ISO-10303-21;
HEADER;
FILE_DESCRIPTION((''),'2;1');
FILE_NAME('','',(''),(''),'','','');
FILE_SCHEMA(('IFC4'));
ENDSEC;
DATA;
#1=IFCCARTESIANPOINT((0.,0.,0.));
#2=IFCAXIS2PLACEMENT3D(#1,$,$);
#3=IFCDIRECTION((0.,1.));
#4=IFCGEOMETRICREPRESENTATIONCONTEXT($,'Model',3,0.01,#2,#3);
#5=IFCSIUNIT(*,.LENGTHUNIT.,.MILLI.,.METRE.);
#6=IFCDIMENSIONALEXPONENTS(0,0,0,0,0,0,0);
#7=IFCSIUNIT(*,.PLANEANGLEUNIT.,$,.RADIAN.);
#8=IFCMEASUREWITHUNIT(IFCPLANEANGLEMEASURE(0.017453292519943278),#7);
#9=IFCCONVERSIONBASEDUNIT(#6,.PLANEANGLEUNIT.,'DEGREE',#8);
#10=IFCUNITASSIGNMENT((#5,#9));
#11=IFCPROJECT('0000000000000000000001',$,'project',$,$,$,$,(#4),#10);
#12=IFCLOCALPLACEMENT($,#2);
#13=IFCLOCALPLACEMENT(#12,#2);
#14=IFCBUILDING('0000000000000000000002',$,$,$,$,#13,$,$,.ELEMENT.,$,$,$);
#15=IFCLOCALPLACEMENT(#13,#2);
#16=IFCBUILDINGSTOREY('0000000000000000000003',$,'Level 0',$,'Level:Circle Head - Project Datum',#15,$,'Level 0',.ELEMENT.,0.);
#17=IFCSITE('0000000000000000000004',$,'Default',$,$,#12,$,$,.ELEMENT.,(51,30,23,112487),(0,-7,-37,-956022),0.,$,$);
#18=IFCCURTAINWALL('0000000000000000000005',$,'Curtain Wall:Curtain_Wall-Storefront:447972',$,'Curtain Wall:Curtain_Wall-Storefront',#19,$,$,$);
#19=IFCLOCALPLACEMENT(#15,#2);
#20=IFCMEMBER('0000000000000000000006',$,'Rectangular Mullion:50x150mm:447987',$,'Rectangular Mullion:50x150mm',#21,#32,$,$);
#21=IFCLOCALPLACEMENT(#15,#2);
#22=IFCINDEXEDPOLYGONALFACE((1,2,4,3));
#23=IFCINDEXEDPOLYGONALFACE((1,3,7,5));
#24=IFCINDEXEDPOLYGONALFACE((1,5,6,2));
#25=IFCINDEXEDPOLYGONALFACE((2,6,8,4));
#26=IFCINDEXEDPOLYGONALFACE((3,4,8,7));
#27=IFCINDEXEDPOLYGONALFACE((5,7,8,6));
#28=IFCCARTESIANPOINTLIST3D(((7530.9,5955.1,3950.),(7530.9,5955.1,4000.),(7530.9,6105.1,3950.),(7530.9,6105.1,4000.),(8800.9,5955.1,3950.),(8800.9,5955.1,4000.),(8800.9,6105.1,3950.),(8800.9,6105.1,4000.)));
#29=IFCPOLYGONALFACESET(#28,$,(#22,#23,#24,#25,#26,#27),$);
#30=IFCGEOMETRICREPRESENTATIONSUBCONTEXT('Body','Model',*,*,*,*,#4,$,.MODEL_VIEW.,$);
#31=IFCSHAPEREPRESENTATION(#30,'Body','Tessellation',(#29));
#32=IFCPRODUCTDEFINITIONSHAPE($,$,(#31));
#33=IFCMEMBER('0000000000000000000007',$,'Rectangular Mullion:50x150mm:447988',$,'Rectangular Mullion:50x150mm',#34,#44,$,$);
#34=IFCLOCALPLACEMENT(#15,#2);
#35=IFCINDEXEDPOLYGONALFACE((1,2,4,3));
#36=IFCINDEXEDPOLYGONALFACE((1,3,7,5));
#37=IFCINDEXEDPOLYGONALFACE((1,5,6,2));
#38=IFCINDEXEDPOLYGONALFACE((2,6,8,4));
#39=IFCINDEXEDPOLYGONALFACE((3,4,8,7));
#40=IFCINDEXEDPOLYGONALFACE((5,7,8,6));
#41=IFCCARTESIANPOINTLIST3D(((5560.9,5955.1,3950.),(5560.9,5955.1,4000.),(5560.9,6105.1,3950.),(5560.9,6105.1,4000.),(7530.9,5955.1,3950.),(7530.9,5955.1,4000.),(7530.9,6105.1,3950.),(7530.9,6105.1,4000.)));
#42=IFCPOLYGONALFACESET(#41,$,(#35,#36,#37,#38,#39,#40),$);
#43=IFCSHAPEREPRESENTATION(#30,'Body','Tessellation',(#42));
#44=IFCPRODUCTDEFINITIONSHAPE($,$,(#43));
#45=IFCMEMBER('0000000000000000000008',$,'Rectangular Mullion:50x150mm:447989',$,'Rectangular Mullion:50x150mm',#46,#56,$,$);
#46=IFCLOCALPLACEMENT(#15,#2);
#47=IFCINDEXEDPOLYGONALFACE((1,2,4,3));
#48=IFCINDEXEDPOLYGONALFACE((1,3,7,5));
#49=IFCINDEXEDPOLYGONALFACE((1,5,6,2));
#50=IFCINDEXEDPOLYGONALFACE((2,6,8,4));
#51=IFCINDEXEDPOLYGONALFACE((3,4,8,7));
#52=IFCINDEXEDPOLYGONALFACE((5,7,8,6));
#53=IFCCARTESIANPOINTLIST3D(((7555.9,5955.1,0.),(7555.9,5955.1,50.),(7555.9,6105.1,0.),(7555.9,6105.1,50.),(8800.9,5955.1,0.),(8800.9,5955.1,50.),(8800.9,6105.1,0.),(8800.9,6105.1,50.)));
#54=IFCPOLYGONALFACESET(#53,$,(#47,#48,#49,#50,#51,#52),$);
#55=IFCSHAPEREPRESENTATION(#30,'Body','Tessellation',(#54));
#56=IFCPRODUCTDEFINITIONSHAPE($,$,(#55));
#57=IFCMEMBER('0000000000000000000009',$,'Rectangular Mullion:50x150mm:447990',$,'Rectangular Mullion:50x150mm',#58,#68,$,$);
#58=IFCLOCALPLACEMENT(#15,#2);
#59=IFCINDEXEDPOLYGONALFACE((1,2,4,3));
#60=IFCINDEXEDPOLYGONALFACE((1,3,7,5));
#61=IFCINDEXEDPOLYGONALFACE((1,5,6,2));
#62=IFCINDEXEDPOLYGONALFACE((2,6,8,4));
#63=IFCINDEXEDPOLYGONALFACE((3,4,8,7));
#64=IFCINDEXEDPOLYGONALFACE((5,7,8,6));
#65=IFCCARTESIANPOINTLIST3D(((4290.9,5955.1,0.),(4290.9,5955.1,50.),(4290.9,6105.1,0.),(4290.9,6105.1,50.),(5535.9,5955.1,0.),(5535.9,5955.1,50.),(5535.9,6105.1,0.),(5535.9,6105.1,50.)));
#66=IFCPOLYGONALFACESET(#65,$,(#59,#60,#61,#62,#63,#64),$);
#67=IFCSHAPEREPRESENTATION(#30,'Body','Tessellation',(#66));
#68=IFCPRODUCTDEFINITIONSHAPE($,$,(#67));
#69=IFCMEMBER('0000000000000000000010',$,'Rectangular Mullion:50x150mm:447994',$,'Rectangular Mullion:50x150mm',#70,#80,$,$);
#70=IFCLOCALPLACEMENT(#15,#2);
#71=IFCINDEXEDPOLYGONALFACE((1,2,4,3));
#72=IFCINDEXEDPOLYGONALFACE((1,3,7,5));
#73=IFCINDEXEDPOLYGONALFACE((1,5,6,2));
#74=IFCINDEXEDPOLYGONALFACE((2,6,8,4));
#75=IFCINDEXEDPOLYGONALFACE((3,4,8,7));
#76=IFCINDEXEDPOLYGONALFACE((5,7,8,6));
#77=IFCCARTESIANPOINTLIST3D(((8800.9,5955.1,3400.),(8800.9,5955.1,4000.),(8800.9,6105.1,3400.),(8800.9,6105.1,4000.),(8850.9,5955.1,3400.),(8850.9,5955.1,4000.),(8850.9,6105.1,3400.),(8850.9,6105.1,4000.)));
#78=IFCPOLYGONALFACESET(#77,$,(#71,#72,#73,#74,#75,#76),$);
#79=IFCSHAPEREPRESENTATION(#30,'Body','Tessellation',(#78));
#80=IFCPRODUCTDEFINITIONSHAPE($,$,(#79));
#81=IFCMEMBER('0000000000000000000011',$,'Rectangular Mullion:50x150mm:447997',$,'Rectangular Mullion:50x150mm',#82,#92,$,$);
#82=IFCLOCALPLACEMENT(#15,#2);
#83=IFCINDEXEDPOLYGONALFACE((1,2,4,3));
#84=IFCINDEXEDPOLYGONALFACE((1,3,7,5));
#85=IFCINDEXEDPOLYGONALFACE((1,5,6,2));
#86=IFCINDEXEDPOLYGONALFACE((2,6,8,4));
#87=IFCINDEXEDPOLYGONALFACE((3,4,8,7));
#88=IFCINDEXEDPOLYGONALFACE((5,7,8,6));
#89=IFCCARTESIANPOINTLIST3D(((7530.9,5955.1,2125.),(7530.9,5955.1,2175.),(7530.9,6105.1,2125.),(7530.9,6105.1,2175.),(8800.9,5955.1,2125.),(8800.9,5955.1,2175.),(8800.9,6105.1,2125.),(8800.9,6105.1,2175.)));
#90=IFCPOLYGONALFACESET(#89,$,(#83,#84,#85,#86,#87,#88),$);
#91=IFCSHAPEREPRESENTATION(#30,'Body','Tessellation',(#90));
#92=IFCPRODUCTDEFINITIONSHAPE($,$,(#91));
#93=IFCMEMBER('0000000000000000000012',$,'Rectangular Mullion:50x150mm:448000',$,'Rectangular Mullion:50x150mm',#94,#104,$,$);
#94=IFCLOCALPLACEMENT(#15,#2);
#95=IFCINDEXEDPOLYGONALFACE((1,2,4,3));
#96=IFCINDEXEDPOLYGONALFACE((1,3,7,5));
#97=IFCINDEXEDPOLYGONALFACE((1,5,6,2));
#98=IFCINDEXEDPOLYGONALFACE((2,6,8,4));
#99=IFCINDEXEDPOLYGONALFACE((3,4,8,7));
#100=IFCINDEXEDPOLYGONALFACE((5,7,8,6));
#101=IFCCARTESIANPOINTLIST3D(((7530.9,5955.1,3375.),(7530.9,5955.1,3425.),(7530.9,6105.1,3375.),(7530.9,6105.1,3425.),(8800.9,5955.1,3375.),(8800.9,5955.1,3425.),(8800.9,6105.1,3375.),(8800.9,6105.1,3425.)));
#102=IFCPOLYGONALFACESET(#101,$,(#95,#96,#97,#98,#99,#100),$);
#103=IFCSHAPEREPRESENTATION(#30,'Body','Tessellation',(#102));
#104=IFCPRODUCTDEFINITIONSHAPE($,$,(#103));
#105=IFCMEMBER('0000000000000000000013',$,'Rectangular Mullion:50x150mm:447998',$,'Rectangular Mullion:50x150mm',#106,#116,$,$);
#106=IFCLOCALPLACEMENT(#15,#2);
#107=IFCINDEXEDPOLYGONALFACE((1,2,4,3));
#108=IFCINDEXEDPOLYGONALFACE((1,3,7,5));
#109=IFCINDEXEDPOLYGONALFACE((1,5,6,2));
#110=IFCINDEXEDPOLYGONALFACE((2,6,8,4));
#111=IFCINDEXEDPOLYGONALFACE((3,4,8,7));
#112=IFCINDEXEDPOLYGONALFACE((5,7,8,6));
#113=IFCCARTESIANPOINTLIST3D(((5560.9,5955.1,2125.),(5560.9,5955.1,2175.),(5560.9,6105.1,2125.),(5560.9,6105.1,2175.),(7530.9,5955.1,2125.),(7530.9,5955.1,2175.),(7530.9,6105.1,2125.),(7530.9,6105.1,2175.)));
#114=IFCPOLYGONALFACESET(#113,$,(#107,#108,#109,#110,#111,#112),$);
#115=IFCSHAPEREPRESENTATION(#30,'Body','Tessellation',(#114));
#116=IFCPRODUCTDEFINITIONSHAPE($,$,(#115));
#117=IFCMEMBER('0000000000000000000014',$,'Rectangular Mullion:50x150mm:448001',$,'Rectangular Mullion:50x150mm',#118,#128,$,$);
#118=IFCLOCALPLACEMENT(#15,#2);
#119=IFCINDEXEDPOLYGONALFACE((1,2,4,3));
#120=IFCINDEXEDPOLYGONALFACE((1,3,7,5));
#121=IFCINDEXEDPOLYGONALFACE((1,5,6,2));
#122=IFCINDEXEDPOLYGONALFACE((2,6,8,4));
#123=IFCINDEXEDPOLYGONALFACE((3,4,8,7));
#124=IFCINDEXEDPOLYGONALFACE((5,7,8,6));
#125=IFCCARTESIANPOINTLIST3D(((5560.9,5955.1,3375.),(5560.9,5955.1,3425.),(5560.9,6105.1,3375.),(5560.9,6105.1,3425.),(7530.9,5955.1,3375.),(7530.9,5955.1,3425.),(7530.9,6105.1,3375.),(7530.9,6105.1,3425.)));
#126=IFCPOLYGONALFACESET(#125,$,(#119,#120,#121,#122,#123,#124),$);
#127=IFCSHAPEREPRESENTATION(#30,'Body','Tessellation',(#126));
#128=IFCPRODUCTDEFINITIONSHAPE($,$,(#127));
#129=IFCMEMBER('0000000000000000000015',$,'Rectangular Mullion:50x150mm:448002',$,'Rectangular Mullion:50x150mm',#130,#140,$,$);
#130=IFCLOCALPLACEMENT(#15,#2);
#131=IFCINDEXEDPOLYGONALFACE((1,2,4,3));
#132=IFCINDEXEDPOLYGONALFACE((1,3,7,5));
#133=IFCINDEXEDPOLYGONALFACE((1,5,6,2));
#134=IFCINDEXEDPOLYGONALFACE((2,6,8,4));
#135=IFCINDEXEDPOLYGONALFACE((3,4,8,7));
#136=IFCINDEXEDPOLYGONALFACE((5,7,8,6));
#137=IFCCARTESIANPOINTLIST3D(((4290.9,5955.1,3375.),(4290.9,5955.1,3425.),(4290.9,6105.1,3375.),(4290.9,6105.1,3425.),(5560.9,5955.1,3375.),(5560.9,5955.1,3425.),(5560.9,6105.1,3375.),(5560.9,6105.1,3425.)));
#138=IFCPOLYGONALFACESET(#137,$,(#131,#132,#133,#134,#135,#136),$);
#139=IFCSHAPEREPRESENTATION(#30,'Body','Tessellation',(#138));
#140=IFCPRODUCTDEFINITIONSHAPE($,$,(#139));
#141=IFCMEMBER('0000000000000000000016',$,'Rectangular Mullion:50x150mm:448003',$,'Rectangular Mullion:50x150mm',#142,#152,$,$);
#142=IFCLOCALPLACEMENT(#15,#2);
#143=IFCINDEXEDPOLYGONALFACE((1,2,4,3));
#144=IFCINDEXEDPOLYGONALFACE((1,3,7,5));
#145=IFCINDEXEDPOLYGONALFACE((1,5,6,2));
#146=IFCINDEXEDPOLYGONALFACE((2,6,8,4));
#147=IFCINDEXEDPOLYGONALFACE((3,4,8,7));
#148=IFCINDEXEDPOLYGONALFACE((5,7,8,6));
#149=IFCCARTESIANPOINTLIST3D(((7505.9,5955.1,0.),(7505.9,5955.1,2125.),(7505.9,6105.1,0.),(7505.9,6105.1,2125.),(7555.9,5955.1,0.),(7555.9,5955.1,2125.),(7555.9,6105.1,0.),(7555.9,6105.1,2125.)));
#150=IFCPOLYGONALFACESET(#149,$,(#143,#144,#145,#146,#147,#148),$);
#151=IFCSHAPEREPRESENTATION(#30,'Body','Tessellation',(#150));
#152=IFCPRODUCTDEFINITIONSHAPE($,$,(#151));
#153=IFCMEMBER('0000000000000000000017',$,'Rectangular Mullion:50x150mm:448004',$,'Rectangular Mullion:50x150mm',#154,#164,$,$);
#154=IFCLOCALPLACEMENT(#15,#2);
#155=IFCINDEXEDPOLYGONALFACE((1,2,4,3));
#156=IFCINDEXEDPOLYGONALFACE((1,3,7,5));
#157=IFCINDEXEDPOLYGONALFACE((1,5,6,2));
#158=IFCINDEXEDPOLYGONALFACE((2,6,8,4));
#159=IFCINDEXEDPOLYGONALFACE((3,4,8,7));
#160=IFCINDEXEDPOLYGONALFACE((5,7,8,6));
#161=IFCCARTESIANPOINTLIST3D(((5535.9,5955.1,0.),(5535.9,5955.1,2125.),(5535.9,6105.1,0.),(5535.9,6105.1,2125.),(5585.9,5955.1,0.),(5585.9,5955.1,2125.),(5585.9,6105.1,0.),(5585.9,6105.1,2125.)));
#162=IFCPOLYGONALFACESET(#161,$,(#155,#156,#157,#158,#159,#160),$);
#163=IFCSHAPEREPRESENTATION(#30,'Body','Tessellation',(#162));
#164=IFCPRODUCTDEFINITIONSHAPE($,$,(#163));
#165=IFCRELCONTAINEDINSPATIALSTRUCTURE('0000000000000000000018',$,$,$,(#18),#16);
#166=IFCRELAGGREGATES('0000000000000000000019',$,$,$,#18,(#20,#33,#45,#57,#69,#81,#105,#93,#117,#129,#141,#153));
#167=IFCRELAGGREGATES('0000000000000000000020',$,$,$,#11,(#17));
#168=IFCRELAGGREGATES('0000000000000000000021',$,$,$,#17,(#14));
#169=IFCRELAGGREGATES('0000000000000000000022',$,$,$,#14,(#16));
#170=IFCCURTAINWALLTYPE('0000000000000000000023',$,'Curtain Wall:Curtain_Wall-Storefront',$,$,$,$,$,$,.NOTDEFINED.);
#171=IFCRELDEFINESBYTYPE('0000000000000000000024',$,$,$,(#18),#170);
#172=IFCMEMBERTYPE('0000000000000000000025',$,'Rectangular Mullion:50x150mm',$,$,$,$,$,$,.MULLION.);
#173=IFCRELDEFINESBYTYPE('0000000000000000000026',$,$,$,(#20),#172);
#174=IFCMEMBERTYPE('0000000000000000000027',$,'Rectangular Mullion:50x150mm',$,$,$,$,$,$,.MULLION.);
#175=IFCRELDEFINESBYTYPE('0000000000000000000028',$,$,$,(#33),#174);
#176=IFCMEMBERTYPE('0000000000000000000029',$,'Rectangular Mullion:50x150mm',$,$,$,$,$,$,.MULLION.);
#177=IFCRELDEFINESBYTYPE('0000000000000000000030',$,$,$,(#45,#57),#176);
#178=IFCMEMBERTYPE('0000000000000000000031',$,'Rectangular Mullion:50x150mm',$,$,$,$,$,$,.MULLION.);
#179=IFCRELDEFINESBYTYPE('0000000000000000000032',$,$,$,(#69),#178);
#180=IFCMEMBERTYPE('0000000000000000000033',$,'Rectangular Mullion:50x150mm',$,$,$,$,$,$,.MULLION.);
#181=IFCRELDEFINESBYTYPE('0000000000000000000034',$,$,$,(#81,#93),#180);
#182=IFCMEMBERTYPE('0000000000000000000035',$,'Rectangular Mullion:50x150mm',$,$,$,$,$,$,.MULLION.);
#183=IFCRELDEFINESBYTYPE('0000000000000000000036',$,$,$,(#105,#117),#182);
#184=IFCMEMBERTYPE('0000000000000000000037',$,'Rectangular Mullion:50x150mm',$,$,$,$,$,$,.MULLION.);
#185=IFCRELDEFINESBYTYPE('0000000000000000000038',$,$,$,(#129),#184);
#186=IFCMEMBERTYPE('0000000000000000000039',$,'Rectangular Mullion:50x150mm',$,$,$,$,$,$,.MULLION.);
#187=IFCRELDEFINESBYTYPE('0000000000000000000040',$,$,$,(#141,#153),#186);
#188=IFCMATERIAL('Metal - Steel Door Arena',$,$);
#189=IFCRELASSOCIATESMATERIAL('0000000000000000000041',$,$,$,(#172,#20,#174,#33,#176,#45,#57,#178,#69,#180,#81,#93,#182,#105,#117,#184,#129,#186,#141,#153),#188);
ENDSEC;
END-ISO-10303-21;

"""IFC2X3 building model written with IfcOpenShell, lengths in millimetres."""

from ifc_helpers import new_model, entity, si_unit, converted_unit, direction, frame, origin, origin_2d_with_axis, place, context, subcontext, project, spatial, rectangle, extrude, source, transform, mapped, material, type_object, type_shapes, element, aggregate, save


model = new_model("IFC2X3")

# Units and contexts
model_context = context("Model", 3, precision=0.01, world=origin(), true_north=direction((0.0, 1.0)))
body_context = subcontext(model_context, "Body", "Model", "MODEL_VIEW")
ifc_project = project(units=[si_unit("LENGTHUNIT", "METRE", prefix="MILLI"), converted_unit("PLANEANGLEUNIT", "DEGREE", entity("IfcPlaneAngleMeasure", 0.017453292519943278), si_unit("PLANEANGLEUNIT", "RADIAN"), dimensions=[0, 0, 0, 0, 0, 0, 0])], contexts=[model_context])

# Site, building, storey
site_placement = place(None, origin())
site = spatial("IfcSite", under=ifc_project, at=site_placement, Name="Default", CompositionType="ELEMENT", RefLatitude=(51, 30, 23, 112487), RefLongitude=(0, -7, -37, -956022), RefElevation=0.0)
building_placement = place(site_placement, origin())
building = spatial("IfcBuilding", under=site, at=building_placement, CompositionType="ELEMENT")
storey_placement = place(building_placement, origin())
storey = spatial("IfcBuildingStorey", under=building, at=storey_placement, Name="Level 0", ObjectType="Level:Circle Head - Project Datum", LongName="Level 0", CompositionType="ELEMENT", Elevation=0.0)

# Curtain wall, members
curtain_wall_type = type_object("IfcCurtainWallType", Name="Curtain Wall:Curtain_Wall-Storefront", PredefinedType="NOTDEFINED")
curtain_wall_placement = place(storey_placement, origin())
curtain_wall = element("IfcCurtainWall", 1, at=curtain_wall_placement, inside=storey, type_object=curtain_wall_type, Name="Curtain Wall:Curtain_Wall-Storefront:447972", ObjectType="Curtain Wall:Curtain_Wall-Storefront")
ifc_material_1 = material(Name="Metal - Steel Door Arena")
member_type_1 = type_object("IfcMemberType", Name="Rectangular Mullion:50x150mm", PredefinedType="MULLION", material=ifc_material_1)
shared_shape_1 = source(origin(), body_context, "Body", "SweptSolid", [
    extrude(rectangle(XDim=50.0, YDim=150.0, at=origin_2d_with_axis()), frame((-25.0, 0.0, -1270.0), z_axis=(0.0, 0.0, 1.0), x_axis=(-1.0, 0.0, 0.0)), (0.0, 0.0, 1.0), 1270.0),
])
type_shapes(member_type_1, [shared_shape_1])
member_1_placement = place(curtain_wall_placement, frame((7530.9, 6030.1, 4000.0), z_axis=(-1.0, 0.0, 0.0), x_axis=(0.0, 0.0, 1.0)))
member_1 = element("IfcMember", 2, at=member_1_placement, type_object=member_type_1, material=ifc_material_1, Name="Rectangular Mullion:50x150mm:447987", ObjectType="Rectangular Mullion:50x150mm", context=body_context, shape_type="MappedRepresentation", body=[
    mapped(shared_shape_1, transform((0.0, 0.0, 0.0), scale=1.0)),
])
member_type_2 = type_object("IfcMemberType", Name="Rectangular Mullion:50x150mm", PredefinedType="MULLION", material=ifc_material_1)
shared_shape_2 = source(origin(), body_context, "Body", "SweptSolid", [
    extrude(rectangle(XDim=50.0, YDim=150.0, at=origin_2d_with_axis()), frame((-25.0, 0.0, -1970.0), z_axis=(0.0, 0.0, 1.0), x_axis=(-1.0, 0.0, 0.0)), (0.0, 0.0, 1.0), 1970.0),
])
type_shapes(member_type_2, [shared_shape_2])
member_2_placement = place(curtain_wall_placement, frame((5560.9, 6030.1, 4000.0), z_axis=(-1.0, 0.0, 0.0), x_axis=(0.0, 0.0, 1.0)))
member_2 = element("IfcMember", 3, at=member_2_placement, type_object=member_type_2, material=ifc_material_1, Name="Rectangular Mullion:50x150mm:447988", ObjectType="Rectangular Mullion:50x150mm", context=body_context, shape_type="MappedRepresentation", body=[
    mapped(shared_shape_2, transform((0.0, 0.0, 0.0), scale=1.0)),
])
member_type_3 = type_object("IfcMemberType", Name="Rectangular Mullion:50x150mm", PredefinedType="MULLION", material=ifc_material_1)
shared_shape_3 = source(origin(), body_context, "Body", "SweptSolid", [
    extrude(rectangle(XDim=50.0, YDim=150.0, at=origin_2d_with_axis()), frame((-25.0, 0.0, -1245.0), z_axis=(0.0, 0.0, 1.0), x_axis=(-1.0, 0.0, 0.0)), (0.0, 0.0, 1.0), 1245.0),
])
type_shapes(member_type_3, [shared_shape_3])
member_3_placement = place(curtain_wall_placement, frame((8800.9, 6030.1, 0.0), z_axis=(1.0, 0.0, 0.0), x_axis=(0.0, 0.0, -1.0)))
member_3 = element("IfcMember", 4, at=member_3_placement, type_object=member_type_3, material=ifc_material_1, Name="Rectangular Mullion:50x150mm:447989", ObjectType="Rectangular Mullion:50x150mm", context=body_context, shape_type="MappedRepresentation", body=[
    mapped(shared_shape_3, transform((0.0, 0.0, 0.0), scale=1.0)),
])
member_4_placement = place(curtain_wall_placement, frame((5535.9, 6030.1, 0.0), z_axis=(1.0, 0.0, 0.0), x_axis=(0.0, 0.0, -1.0)))
member_4 = element("IfcMember", 5, at=member_4_placement, type_object=member_type_3, material=ifc_material_1, Name="Rectangular Mullion:50x150mm:447990", ObjectType="Rectangular Mullion:50x150mm", context=body_context, shape_type="MappedRepresentation", body=[
    mapped(shared_shape_3, transform((0.0, 0.0, 0.0), scale=1.0)),
])
member_type_4 = type_object("IfcMemberType", Name="Rectangular Mullion:50x150mm", PredefinedType="MULLION", material=ifc_material_1)
shared_shape_4 = source(origin(), body_context, "Body", "SweptSolid", [
    extrude(rectangle(XDim=50.0, YDim=150.0, at=origin_2d_with_axis()), frame((-25.0, 0.0, -600.0), z_axis=(0.0, 0.0, 1.0), x_axis=(-1.0, 0.0, 0.0)), (0.0, 0.0, 1.0), 600.0),
])
type_shapes(member_type_4, [shared_shape_4])
member_5_placement = place(curtain_wall_placement, frame((8850.9, 6030.1, 4000.0)))
member_5 = element("IfcMember", 6, at=member_5_placement, type_object=member_type_4, material=ifc_material_1, Name="Rectangular Mullion:50x150mm:447994", ObjectType="Rectangular Mullion:50x150mm", context=body_context, shape_type="MappedRepresentation", body=[
    mapped(shared_shape_4, transform((0.0, 0.0, 0.0), scale=1.0)),
])
member_type_5 = type_object("IfcMemberType", Name="Rectangular Mullion:50x150mm", PredefinedType="MULLION", material=ifc_material_1)
shared_shape_5 = source(origin(), body_context, "Body", "SweptSolid", [
    extrude(rectangle(XDim=50.0, YDim=150.0, at=origin_2d_with_axis()), frame((0.0, 0.0, -1270.0), z_axis=(0.0, 0.0, 1.0), x_axis=(-1.0, 0.0, 0.0)), (0.0, 0.0, 1.0), 1270.0),
])
type_shapes(member_type_5, [shared_shape_5])
member_6_placement = place(curtain_wall_placement, frame((7530.9, 6030.1, 2150.0), z_axis=(-1.0, 0.0, 0.0), x_axis=(0.0, 0.0, 1.0)))
member_6 = element("IfcMember", 7, at=member_6_placement, type_object=member_type_5, material=ifc_material_1, Name="Rectangular Mullion:50x150mm:447997", ObjectType="Rectangular Mullion:50x150mm", context=body_context, shape_type="MappedRepresentation", body=[
    mapped(shared_shape_5, transform((0.0, 0.0, 0.0), scale=1.0)),
])
member_7_placement = place(curtain_wall_placement, frame((7530.9, 6030.1, 3400.0), z_axis=(-1.0, 0.0, 0.0), x_axis=(0.0, 0.0, 1.0)))
member_7 = element("IfcMember", 8, at=member_7_placement, type_object=member_type_5, material=ifc_material_1, Name="Rectangular Mullion:50x150mm:448000", ObjectType="Rectangular Mullion:50x150mm", context=body_context, shape_type="MappedRepresentation", body=[
    mapped(shared_shape_5, transform((0.0, 0.0, 0.0), scale=1.0)),
])
member_type_6 = type_object("IfcMemberType", Name="Rectangular Mullion:50x150mm", PredefinedType="MULLION", material=ifc_material_1)
shared_shape_6 = source(origin(), body_context, "Body", "SweptSolid", [
    extrude(rectangle(XDim=50.0, YDim=150.0, at=origin_2d_with_axis()), frame((0.0, 0.0, -1970.0), z_axis=(0.0, 0.0, 1.0), x_axis=(-1.0, 0.0, 0.0)), (0.0, 0.0, 1.0), 1970.0),
])
type_shapes(member_type_6, [shared_shape_6])
member_8_placement = place(curtain_wall_placement, frame((5560.9, 6030.1, 2150.0), z_axis=(-1.0, 0.0, 0.0), x_axis=(0.0, 0.0, 1.0)))
member_8 = element("IfcMember", 9, at=member_8_placement, type_object=member_type_6, material=ifc_material_1, Name="Rectangular Mullion:50x150mm:447998", ObjectType="Rectangular Mullion:50x150mm", context=body_context, shape_type="MappedRepresentation", body=[
    mapped(shared_shape_6, transform((0.0, 0.0, 0.0), scale=1.0)),
])
member_9_placement = place(curtain_wall_placement, frame((5560.9, 6030.1, 3400.0), z_axis=(-1.0, 0.0, 0.0), x_axis=(0.0, 0.0, 1.0)))
member_9 = element("IfcMember", 10, at=member_9_placement, type_object=member_type_6, material=ifc_material_1, Name="Rectangular Mullion:50x150mm:448001", ObjectType="Rectangular Mullion:50x150mm", context=body_context, shape_type="MappedRepresentation", body=[
    mapped(shared_shape_6, transform((0.0, 0.0, 0.0), scale=1.0)),
])
member_type_7 = type_object("IfcMemberType", Name="Rectangular Mullion:50x150mm", PredefinedType="MULLION", material=ifc_material_1)
shared_shape_7 = source(origin(), body_context, "Body", "SweptSolid", [
    extrude(rectangle(XDim=50.0, YDim=150.0, at=origin_2d_with_axis()), frame((0.0, 0.0, -1270.0), z_axis=(0.0, 0.0, 1.0), x_axis=(-1.0, 0.0, 0.0)), (0.0, 0.0, 1.0), 1270.0),
])
type_shapes(member_type_7, [shared_shape_7])
member_10_placement = place(curtain_wall_placement, frame((4290.9, 6030.1, 3400.0), z_axis=(-1.0, 0.0, 0.0), x_axis=(0.0, 0.0, 1.0)))
member_10 = element("IfcMember", 11, at=member_10_placement, type_object=member_type_7, material=ifc_material_1, Name="Rectangular Mullion:50x150mm:448002", ObjectType="Rectangular Mullion:50x150mm", context=body_context, shape_type="MappedRepresentation", body=[
    mapped(shared_shape_7, transform((0.0, 0.0, 0.0), scale=1.0)),
])
member_type_8 = type_object("IfcMemberType", Name="Rectangular Mullion:50x150mm", PredefinedType="MULLION", material=ifc_material_1)
shared_shape_8 = source(origin(), body_context, "Body", "SweptSolid", [
    extrude(rectangle(XDim=50.0, YDim=150.0, at=origin_2d_with_axis()), frame((0.0, 0.0, -2125.0), z_axis=(0.0, 0.0, 1.0), x_axis=(-1.0, 0.0, 0.0)), (0.0, 0.0, 1.0), 2125.0),
])
type_shapes(member_type_8, [shared_shape_8])
member_11_placement = place(curtain_wall_placement, frame((7530.9, 6030.1, 0.0), z_axis=(0.0, 0.0, -1.0), x_axis=(-1.0, 0.0, 0.0)))
member_11 = element("IfcMember", 12, at=member_11_placement, type_object=member_type_8, material=ifc_material_1, Name="Rectangular Mullion:50x150mm:448003", ObjectType="Rectangular Mullion:50x150mm", context=body_context, shape_type="MappedRepresentation", body=[
    mapped(shared_shape_8, transform((0.0, 0.0, 0.0), scale=1.0)),
])
member_12_placement = place(curtain_wall_placement, frame((5560.9, 6030.1, 0.0), z_axis=(0.0, 0.0, -1.0), x_axis=(-1.0, 0.0, 0.0)))
member_12 = element("IfcMember", 13, at=member_12_placement, type_object=member_type_8, material=ifc_material_1, Name="Rectangular Mullion:50x150mm:448004", ObjectType="Rectangular Mullion:50x150mm", context=body_context, shape_type="MappedRepresentation", body=[
    mapped(shared_shape_8, transform((0.0, 0.0, 0.0), scale=1.0)),
])
aggregate(curtain_wall, [member_1, member_2, member_3, member_4, member_5, member_6, member_8, member_7, member_9, member_10, member_11, member_12])

save(model, "model.ifc")
